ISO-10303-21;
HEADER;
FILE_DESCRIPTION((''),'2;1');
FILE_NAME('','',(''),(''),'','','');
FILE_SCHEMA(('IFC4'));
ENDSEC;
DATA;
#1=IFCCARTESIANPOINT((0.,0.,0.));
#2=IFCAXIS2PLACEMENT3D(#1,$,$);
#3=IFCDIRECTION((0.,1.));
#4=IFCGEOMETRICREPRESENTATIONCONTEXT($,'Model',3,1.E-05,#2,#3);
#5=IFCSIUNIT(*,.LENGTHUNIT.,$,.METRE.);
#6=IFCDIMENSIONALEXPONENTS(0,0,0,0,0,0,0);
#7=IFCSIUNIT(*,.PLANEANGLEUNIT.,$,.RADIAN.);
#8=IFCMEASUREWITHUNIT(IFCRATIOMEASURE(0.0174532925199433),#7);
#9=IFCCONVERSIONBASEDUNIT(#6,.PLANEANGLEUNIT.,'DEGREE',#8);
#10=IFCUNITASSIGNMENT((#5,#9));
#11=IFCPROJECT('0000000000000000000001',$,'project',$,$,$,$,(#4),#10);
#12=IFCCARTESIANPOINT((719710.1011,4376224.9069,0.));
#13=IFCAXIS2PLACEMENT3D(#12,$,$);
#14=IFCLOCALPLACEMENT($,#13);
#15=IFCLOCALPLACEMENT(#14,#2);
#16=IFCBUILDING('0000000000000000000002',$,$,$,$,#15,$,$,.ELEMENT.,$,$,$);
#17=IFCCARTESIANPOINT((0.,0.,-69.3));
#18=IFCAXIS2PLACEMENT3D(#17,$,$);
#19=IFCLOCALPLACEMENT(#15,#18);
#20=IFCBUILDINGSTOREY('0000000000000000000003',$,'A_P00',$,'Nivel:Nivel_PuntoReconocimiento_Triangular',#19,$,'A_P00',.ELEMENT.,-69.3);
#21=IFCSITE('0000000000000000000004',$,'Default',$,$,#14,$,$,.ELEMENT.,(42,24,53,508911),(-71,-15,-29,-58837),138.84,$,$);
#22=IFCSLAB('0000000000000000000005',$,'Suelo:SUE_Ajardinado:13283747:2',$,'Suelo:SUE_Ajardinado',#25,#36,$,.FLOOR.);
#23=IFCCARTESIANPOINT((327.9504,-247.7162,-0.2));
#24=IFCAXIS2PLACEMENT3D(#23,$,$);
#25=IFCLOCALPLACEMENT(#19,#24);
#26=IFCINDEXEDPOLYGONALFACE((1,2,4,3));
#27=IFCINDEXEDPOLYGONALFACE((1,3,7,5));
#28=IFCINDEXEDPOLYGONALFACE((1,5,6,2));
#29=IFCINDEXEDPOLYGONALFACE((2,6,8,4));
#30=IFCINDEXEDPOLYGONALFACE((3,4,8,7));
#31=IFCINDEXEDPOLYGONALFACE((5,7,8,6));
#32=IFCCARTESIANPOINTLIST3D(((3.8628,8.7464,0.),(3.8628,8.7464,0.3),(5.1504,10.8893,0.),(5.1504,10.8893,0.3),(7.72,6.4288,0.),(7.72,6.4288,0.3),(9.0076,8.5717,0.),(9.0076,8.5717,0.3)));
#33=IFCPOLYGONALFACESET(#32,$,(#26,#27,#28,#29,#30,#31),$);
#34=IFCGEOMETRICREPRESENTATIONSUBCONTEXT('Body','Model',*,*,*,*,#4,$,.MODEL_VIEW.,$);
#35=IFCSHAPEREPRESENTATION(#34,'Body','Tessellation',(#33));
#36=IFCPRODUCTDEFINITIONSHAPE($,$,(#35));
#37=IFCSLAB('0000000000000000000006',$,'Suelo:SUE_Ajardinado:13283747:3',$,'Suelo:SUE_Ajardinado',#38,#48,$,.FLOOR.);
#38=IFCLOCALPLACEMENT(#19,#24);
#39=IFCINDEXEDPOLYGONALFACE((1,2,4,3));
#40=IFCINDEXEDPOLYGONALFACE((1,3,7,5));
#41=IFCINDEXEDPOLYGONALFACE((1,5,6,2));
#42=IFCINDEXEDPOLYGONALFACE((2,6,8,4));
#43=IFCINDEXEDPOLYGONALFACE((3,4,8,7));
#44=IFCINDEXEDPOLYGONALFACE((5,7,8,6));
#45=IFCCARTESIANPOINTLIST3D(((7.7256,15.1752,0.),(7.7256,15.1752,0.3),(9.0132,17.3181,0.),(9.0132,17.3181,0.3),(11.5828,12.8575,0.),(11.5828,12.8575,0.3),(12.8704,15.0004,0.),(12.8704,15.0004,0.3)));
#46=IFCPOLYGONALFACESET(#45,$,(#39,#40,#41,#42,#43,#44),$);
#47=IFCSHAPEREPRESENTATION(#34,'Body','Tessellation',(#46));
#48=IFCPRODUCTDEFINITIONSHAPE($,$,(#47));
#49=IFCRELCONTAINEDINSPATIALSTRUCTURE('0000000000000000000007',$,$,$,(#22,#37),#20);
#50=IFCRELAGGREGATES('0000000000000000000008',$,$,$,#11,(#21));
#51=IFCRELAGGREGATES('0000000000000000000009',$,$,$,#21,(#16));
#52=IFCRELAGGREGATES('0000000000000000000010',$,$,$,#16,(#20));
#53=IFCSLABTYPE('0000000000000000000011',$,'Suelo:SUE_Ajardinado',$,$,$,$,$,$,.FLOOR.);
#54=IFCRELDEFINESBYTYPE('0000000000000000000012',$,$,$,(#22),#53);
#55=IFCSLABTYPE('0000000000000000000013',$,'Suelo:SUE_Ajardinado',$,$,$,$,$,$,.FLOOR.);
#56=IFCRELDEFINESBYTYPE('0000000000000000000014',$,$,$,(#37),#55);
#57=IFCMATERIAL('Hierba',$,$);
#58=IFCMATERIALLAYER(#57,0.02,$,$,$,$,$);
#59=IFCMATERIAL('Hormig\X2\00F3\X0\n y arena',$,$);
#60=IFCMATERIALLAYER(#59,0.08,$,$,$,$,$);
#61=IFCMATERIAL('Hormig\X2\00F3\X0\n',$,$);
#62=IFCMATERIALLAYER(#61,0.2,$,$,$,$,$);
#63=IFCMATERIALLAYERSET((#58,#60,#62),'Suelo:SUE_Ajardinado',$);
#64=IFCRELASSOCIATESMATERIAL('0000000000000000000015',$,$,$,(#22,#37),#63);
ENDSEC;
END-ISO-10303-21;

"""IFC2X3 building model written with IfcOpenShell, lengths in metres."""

from ifc_helpers import new_model, entity, si_unit, converted_unit, direction, frame, frame_2d, origin, place, context, subcontext, project, spatial, rectangle, extrude, material, layer, layer_set, layer_usage, type_object, element, save


model = new_model("IFC2X3")

# Units and contexts
model_context = context("Model", 3, precision=1e-05, world=origin(), true_north=direction((0.0, 1.0)))
body_context = subcontext(model_context, "Body", "Model", "MODEL_VIEW")
ifc_project = project(units=[si_unit("LENGTHUNIT", "METRE"), converted_unit("PLANEANGLEUNIT", "DEGREE", entity("IfcRatioMeasure", 0.0174532925199433), si_unit("PLANEANGLEUNIT", "RADIAN"), dimensions=[0, 0, 0, 0, 0, 0, 0])], contexts=[model_context])

# Site, building, storey
site_placement = place(None, frame((719710.1011, 4376224.9069, 0.0)))
site = spatial("IfcSite", under=ifc_project, at=site_placement, Name="Default", CompositionType="ELEMENT", RefLatitude=(42, 24, 53, 508911), RefLongitude=(-71, -15, -29, -58837), RefElevation=138.84)
building_placement = place(site_placement, origin())
building = spatial("IfcBuilding", under=site, at=building_placement, CompositionType="ELEMENT")
storey_placement = place(building_placement, frame((0.0, 0.0, -69.3)))
storey = spatial("IfcBuildingStorey", under=building, at=storey_placement, Name="A_P00", ObjectType="Nivel:Nivel_PuntoReconocimiento_Triangular", LongName="A_P00", CompositionType="ELEMENT", Elevation=-69.3)

# Shared definitions
ifc_material_1 = material(Name="Hierba")
ifc_layer_1 = layer(ifc_material_1, 0.02)
ifc_material_2 = material(Name="Hormigón y arena")
ifc_layer_2 = layer(ifc_material_2, 0.08)
ifc_material_3 = material(Name="Hormigón")
ifc_layer_3 = layer(ifc_material_3, 0.2)
ifc_layer_set_1 = layer_set([ifc_layer_1, ifc_layer_2, ifc_layer_3], Name="Suelo:SUE_Ajardinado")

# Slabs
ifc_layer_usage_1 = layer_usage(ifc_layer_set_1, "AXIS3", "POSITIVE", 0.0)
slab_type_1 = type_object("IfcSlabType", Name="Suelo:SUE_Ajardinado", PredefinedType="FLOOR")
slab_1_placement = place(storey_placement, frame((327.9504, -247.7162, -0.2)))
element("IfcSlab", 1, at=slab_1_placement, inside=storey, type_object=slab_type_1, material=ifc_layer_usage_1, Name="Suelo:SUE_Ajardinado:13283747:2", ObjectType="Suelo:SUE_Ajardinado", PredefinedType="FLOOR", context=body_context, shape_type="SweptSolid", body=[
    extrude(rectangle(XDim=2.5, YDim=4.5, at=frame_2d((3.8628, -6.4288), x_axis=(-0.515038, 0.857167))), frame((10.298, 15.0878, 0.3), z_axis=(0.0, 0.0, -1.0), x_axis=(-1.0, 0.0, 0.0)), (0.0, 0.0, 1.0), 0.3),
])
slab_type_2 = type_object("IfcSlabType", Name="Suelo:SUE_Ajardinado", PredefinedType="FLOOR")
slab_2_placement = place(storey_placement, frame((327.9504, -247.7162, -0.2)))
element("IfcSlab", 2, at=slab_2_placement, inside=storey, type_object=slab_type_2, material=ifc_layer_usage_1, Name="Suelo:SUE_Ajardinado:13283747:3", ObjectType="Suelo:SUE_Ajardinado", PredefinedType="FLOOR", context=body_context, shape_type="SweptSolid", body=[
    extrude(rectangle(XDim=2.5, YDim=4.5, at=frame_2d((0.0, 0.0), x_axis=(-0.515038, 0.857167))), frame((10.298, 15.0878, 0.3), z_axis=(0.0, 0.0, -1.0), x_axis=(-1.0, 0.0, 0.0)), (0.0, 0.0, 1.0), 0.3),
])

save(model, "model.ifc")
